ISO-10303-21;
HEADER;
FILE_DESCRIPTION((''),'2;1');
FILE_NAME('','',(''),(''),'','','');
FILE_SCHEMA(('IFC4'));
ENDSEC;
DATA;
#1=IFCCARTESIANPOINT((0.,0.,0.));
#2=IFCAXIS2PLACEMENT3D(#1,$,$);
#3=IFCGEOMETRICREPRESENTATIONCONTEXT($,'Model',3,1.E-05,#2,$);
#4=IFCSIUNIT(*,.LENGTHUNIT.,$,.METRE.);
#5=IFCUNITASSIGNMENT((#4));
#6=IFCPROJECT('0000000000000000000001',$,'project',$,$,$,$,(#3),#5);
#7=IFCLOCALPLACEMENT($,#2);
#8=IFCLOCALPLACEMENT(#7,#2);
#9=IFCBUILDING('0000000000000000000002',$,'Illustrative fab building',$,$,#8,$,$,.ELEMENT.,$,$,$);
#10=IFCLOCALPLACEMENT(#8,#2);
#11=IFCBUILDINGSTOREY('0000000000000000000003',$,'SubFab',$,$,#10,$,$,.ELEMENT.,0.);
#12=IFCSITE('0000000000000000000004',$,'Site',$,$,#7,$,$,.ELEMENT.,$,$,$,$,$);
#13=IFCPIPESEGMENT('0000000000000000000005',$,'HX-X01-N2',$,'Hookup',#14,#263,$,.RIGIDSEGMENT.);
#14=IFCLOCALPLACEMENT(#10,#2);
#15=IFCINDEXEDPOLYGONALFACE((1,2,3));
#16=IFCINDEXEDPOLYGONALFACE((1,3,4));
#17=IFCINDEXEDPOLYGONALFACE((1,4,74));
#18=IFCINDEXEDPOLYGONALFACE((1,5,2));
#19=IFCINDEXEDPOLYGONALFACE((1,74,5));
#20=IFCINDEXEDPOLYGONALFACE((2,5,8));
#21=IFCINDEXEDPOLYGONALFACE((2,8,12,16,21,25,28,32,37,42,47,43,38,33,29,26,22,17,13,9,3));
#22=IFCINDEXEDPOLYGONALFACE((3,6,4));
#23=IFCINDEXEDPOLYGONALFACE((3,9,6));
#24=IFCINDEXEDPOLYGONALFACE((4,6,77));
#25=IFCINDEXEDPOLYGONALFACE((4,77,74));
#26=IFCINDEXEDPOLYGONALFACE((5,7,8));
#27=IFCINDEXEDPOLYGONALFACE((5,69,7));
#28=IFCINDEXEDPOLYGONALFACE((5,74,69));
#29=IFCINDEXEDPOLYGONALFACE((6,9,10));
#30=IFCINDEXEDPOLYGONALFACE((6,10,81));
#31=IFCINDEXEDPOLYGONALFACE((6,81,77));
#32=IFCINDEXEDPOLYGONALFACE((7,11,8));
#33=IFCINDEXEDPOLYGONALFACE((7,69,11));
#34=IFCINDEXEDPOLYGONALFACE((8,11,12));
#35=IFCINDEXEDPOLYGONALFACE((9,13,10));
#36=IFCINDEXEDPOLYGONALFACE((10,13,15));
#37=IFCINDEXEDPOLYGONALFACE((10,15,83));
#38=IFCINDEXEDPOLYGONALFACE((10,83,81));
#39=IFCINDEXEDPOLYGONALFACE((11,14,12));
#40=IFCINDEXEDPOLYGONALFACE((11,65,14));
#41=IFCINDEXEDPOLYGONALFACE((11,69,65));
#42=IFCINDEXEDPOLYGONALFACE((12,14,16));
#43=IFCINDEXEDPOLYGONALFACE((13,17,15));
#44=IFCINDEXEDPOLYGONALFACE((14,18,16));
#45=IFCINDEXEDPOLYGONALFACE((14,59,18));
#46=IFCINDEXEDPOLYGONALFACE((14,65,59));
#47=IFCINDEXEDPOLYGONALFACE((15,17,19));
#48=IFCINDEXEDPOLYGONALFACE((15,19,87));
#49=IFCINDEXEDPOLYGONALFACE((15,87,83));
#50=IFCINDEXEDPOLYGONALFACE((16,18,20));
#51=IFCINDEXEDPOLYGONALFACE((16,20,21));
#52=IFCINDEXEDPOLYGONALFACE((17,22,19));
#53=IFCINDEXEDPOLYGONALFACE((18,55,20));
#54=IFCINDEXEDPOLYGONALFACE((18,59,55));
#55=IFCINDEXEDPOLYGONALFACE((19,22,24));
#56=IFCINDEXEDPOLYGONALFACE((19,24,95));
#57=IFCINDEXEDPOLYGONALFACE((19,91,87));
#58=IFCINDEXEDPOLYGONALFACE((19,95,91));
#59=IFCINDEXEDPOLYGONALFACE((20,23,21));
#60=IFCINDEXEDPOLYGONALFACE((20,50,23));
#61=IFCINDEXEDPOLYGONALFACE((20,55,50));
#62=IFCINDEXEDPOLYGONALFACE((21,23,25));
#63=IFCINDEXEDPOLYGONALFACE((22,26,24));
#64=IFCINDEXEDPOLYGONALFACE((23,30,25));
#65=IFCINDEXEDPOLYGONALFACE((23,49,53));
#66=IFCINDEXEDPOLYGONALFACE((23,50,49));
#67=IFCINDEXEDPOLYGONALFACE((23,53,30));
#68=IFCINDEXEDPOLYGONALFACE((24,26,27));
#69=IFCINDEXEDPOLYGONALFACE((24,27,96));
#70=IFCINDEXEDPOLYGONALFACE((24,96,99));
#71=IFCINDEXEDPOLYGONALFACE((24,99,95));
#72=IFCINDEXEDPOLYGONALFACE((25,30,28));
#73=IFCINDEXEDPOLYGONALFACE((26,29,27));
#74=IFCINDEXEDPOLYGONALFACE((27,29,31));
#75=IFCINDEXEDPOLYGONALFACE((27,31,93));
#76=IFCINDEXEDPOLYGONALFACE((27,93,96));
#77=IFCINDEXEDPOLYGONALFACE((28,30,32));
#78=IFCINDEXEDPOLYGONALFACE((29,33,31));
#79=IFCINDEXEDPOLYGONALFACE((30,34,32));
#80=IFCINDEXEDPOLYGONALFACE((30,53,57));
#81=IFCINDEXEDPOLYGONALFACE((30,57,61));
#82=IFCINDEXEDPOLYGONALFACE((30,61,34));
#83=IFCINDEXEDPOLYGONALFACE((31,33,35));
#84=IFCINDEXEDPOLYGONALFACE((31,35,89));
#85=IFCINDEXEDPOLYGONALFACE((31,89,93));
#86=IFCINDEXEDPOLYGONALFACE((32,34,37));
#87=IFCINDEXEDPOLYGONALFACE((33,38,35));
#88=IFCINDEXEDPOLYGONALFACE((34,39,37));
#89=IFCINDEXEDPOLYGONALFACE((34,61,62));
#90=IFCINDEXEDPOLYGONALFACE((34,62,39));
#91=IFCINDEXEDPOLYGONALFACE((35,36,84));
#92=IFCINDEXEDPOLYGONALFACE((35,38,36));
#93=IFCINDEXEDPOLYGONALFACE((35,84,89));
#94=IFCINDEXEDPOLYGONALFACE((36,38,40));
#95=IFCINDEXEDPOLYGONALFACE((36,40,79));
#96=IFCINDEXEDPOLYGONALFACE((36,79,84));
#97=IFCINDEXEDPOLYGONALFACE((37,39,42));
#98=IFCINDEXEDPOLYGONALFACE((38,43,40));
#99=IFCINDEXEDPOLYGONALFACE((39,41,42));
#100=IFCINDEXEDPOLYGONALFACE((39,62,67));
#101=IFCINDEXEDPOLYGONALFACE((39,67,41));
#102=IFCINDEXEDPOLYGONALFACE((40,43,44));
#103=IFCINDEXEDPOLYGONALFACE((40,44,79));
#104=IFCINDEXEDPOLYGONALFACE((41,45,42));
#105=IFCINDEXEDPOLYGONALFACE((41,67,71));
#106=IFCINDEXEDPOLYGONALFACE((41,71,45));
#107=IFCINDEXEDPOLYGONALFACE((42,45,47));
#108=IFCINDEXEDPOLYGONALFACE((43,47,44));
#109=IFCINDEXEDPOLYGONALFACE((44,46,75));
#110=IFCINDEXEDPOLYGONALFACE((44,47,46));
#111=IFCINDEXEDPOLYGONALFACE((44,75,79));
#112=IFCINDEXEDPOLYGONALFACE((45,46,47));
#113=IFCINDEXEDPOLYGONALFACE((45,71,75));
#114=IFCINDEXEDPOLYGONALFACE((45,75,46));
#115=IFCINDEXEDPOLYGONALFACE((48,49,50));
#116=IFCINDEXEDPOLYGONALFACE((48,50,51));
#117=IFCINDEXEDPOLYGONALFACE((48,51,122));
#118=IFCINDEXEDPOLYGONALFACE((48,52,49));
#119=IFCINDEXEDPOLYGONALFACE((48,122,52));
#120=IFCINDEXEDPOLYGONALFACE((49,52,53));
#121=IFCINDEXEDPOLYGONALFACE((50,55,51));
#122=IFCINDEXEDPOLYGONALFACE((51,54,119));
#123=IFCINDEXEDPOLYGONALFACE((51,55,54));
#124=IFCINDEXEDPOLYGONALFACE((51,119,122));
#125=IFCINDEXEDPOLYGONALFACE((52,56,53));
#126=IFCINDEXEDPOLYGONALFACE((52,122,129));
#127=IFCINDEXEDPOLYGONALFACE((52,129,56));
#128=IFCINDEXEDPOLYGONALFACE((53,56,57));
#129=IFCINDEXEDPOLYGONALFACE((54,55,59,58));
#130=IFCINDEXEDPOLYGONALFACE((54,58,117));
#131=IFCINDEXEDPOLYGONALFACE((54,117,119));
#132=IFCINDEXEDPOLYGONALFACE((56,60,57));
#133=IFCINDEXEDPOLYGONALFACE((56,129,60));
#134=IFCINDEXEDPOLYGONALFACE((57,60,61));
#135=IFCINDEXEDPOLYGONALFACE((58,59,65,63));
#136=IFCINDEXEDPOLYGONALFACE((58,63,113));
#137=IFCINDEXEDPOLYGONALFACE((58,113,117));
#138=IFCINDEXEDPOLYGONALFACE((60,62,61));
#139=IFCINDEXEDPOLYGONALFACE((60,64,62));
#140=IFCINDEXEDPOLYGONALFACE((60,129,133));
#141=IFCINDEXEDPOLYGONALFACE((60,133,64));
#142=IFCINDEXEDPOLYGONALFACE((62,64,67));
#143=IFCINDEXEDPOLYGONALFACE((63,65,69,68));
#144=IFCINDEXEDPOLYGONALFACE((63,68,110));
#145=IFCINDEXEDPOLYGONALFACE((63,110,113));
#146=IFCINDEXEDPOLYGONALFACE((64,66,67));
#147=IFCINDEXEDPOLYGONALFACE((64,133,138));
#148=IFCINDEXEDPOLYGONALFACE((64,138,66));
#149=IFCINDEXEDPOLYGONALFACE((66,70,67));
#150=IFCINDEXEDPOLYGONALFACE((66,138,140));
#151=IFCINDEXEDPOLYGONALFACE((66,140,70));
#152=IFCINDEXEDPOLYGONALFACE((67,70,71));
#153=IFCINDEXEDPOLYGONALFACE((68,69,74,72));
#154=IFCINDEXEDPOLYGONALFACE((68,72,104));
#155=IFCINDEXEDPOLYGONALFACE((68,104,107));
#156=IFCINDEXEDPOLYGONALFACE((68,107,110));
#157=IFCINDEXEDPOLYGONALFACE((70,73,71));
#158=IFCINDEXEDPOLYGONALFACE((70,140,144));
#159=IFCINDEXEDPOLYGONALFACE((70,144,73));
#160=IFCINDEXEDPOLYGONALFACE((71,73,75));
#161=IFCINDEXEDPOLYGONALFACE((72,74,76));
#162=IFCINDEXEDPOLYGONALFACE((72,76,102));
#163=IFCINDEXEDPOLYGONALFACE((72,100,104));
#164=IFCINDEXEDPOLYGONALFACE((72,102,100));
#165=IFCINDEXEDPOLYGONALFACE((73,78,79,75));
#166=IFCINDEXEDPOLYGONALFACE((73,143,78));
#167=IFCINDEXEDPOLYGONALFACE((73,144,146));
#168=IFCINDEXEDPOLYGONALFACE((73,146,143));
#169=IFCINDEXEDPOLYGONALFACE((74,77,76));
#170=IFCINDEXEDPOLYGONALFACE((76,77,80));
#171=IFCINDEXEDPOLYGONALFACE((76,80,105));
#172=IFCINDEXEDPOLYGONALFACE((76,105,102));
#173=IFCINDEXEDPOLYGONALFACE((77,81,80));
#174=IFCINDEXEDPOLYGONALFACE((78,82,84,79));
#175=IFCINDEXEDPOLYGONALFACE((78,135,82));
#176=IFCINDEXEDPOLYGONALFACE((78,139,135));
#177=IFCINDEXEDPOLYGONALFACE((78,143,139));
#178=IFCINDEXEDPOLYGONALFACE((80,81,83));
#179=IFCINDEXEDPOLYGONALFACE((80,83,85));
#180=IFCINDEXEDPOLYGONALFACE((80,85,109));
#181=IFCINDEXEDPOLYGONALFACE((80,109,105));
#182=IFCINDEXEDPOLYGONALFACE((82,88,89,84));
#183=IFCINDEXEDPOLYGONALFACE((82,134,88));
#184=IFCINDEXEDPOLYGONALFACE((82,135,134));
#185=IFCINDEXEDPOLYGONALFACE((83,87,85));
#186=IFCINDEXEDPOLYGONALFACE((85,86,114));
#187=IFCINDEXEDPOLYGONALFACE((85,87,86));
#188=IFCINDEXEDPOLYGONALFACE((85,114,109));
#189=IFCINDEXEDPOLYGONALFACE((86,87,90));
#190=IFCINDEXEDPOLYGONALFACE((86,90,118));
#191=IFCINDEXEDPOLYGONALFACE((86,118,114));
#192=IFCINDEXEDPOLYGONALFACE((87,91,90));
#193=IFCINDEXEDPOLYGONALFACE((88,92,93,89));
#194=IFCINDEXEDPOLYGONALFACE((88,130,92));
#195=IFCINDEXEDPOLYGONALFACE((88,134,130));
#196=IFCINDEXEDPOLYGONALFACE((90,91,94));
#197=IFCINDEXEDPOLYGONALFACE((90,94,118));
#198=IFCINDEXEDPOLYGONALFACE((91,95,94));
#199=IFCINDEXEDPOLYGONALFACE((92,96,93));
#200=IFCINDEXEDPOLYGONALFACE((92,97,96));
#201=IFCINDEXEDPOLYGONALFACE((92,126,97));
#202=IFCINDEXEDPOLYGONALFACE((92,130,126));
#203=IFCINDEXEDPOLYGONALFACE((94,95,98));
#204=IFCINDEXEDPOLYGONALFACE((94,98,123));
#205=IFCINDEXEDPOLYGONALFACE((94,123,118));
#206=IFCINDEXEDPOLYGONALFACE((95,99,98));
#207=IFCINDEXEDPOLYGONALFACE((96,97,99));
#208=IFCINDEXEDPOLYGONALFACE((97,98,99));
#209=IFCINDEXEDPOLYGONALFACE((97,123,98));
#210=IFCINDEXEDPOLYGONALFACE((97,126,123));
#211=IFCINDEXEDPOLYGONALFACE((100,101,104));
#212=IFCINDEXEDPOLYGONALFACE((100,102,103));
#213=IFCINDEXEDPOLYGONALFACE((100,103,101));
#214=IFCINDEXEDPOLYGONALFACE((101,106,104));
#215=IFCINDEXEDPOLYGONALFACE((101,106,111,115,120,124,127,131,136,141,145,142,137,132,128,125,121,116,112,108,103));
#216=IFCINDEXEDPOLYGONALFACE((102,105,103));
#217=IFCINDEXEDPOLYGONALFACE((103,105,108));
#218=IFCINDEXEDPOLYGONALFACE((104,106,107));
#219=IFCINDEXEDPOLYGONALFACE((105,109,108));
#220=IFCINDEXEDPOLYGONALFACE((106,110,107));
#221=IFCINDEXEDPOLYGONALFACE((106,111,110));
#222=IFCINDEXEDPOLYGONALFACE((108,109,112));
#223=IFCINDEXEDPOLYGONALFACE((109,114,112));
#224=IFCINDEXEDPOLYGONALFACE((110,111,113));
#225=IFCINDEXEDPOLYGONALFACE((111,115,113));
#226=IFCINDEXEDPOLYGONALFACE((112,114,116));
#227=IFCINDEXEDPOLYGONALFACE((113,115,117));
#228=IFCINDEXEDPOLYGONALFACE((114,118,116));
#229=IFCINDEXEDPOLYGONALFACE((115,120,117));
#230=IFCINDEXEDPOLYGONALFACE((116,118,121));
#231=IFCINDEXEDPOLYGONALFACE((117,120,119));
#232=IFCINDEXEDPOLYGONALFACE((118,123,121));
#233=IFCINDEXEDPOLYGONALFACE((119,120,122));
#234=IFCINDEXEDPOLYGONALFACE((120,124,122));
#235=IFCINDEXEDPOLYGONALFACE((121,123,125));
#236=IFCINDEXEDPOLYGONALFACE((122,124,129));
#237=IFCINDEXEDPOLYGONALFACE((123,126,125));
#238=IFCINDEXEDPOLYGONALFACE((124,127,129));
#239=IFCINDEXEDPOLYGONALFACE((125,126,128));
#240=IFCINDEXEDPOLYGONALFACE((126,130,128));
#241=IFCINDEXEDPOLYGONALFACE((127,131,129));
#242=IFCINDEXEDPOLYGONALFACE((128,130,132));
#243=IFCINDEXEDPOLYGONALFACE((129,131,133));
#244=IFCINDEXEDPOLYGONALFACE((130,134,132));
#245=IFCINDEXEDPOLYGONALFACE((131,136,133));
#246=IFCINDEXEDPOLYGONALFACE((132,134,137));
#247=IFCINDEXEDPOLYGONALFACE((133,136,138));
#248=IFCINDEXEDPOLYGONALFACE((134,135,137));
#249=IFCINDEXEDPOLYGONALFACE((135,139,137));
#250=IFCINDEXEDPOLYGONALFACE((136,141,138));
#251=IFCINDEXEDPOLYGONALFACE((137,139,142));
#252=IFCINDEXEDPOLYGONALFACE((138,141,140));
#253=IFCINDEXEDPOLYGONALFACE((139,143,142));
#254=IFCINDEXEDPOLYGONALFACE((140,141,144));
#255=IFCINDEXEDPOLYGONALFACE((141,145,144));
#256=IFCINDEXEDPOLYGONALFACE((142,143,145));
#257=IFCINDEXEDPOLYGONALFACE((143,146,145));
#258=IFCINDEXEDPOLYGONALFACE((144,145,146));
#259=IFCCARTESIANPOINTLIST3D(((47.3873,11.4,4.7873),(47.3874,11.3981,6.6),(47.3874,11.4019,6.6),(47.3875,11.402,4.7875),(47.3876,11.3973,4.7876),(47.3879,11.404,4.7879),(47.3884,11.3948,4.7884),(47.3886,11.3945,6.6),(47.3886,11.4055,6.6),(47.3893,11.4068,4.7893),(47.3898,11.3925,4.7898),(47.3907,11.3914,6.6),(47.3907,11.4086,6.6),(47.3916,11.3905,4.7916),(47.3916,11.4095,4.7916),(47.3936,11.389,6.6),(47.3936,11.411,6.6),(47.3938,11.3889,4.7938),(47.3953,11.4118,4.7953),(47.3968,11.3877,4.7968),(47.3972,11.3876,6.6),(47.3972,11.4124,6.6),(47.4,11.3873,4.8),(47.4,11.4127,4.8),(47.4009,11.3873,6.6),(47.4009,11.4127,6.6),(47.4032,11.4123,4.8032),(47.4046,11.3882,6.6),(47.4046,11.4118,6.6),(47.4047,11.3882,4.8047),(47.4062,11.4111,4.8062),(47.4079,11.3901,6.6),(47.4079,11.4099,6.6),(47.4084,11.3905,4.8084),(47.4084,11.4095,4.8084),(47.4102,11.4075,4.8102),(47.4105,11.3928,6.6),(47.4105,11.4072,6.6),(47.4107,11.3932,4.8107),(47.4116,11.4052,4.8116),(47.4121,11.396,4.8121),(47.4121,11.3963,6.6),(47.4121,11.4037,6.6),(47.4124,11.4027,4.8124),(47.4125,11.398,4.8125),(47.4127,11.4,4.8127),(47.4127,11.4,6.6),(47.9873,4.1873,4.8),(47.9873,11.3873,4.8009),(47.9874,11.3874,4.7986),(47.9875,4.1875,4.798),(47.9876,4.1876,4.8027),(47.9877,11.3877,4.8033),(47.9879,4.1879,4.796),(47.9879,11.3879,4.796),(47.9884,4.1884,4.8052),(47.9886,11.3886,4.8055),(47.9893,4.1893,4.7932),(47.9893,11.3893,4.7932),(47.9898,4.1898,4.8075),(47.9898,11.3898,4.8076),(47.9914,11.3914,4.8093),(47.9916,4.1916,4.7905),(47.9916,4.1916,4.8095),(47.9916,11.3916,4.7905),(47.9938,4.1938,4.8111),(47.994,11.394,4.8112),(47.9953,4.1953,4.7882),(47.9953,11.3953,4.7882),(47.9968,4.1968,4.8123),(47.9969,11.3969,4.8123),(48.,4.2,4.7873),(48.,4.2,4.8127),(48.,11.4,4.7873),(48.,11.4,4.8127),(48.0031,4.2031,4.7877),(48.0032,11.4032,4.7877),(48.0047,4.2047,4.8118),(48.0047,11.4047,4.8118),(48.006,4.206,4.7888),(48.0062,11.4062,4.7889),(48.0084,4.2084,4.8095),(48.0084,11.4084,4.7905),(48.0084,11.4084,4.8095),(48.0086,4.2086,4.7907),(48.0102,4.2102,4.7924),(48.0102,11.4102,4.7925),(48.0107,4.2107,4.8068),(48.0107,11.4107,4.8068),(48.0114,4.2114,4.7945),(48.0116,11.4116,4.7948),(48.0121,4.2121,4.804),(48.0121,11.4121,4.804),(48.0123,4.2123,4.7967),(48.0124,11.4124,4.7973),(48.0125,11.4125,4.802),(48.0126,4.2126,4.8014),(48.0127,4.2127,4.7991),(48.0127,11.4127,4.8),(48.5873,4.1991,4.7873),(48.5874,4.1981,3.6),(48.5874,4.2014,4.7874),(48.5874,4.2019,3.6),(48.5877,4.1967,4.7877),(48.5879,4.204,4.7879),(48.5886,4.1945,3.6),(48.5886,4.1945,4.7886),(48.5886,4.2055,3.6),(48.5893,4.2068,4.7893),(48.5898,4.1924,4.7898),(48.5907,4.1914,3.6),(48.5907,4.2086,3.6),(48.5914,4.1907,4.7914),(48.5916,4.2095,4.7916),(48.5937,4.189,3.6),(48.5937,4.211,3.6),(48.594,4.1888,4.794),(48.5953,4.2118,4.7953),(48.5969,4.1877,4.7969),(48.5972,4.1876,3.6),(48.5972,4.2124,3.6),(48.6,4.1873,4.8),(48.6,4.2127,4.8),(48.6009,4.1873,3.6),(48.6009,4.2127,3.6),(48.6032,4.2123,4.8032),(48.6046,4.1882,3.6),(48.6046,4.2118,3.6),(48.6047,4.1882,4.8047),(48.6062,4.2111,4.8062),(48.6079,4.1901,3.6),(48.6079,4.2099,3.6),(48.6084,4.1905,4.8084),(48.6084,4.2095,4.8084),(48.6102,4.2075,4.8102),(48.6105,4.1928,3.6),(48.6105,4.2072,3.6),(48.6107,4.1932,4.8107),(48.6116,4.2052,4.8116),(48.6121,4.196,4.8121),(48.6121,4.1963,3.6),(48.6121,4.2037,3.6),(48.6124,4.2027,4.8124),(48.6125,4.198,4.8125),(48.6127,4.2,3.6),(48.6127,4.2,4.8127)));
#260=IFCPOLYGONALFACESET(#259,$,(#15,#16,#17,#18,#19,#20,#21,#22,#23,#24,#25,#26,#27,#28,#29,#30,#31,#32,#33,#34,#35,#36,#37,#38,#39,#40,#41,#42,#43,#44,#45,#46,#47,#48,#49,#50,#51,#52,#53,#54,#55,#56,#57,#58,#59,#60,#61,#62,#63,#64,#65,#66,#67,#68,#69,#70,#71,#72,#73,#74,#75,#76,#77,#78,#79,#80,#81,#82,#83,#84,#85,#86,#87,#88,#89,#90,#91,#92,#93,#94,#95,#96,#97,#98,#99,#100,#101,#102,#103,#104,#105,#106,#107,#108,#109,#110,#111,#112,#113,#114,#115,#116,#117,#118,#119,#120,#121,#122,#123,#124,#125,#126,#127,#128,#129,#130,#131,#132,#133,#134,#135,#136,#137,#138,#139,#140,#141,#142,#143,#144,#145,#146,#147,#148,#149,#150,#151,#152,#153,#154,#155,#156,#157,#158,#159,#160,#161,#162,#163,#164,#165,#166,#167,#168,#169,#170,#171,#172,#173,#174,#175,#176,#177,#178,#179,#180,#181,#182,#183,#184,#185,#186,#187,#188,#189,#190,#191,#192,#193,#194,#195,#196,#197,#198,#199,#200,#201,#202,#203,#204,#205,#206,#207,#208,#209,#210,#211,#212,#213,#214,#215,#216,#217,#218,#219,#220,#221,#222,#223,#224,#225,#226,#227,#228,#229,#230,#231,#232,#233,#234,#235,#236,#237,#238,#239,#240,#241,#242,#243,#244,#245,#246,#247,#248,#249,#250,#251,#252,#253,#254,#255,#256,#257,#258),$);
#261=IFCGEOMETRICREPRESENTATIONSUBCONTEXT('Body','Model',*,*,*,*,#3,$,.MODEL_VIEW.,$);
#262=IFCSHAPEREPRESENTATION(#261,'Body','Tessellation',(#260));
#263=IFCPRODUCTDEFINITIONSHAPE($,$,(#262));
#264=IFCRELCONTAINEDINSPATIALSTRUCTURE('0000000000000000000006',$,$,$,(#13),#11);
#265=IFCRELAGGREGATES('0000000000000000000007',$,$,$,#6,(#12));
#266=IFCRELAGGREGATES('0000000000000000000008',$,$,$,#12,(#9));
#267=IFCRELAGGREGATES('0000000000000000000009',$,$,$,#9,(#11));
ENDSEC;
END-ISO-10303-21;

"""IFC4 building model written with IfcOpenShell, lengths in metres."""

from ifc_helpers import new_model, entity, si_unit, origin, place, context, subcontext, project, spatial, element, save


model = new_model("IFC4")

# Units and contexts
model_context = context("Model", 3, precision=1e-05, world=origin())
body_context = subcontext(model_context, "Body", "Model", "MODEL_VIEW")
ifc_project = project(units=[si_unit("LENGTHUNIT", "METRE")], contexts=[model_context])

# Site, building, storey
site_placement = place(None, origin())
site = spatial("IfcSite", under=ifc_project, at=site_placement, Name="Site", CompositionType="ELEMENT")
building_placement = place(site_placement, origin())
building = spatial("IfcBuilding", under=site, at=building_placement, Name="Illustrative fab building", CompositionType="ELEMENT")
storey_placement = place(building_placement, origin())
storey = spatial("IfcBuildingStorey", under=building, at=storey_placement, Name="SubFab", CompositionType="ELEMENT", Elevation=0.0)

# Pipe segment
pipe_segment_1_placement = place(storey_placement, origin())
element("IfcPipeSegment", 1, at=pipe_segment_1_placement, inside=storey, Name="HX-X01-N2", ObjectType="Hookup", PredefinedType="RIGIDSEGMENT", context=body_context, shape_type="AdvancedSweptSolid", body=[
    entity("IfcSweptDiskSolid", entity("IfcPolyline", [entity("IfcCartesianPoint", [48.6, 4.2, 3.6]), entity("IfcCartesianPoint", [48.6, 4.2, 4.8]), entity("IfcCartesianPoint", [48.0, 4.2, 4.8]), entity("IfcCartesianPoint", [48.0, 11.4, 4.8]), entity("IfcCartesianPoint", [47.4, 11.4, 4.8]), entity("IfcCartesianPoint", [47.4, 11.4, 6.6])]), 0.0127),
])

save(model, "model.ifc")
